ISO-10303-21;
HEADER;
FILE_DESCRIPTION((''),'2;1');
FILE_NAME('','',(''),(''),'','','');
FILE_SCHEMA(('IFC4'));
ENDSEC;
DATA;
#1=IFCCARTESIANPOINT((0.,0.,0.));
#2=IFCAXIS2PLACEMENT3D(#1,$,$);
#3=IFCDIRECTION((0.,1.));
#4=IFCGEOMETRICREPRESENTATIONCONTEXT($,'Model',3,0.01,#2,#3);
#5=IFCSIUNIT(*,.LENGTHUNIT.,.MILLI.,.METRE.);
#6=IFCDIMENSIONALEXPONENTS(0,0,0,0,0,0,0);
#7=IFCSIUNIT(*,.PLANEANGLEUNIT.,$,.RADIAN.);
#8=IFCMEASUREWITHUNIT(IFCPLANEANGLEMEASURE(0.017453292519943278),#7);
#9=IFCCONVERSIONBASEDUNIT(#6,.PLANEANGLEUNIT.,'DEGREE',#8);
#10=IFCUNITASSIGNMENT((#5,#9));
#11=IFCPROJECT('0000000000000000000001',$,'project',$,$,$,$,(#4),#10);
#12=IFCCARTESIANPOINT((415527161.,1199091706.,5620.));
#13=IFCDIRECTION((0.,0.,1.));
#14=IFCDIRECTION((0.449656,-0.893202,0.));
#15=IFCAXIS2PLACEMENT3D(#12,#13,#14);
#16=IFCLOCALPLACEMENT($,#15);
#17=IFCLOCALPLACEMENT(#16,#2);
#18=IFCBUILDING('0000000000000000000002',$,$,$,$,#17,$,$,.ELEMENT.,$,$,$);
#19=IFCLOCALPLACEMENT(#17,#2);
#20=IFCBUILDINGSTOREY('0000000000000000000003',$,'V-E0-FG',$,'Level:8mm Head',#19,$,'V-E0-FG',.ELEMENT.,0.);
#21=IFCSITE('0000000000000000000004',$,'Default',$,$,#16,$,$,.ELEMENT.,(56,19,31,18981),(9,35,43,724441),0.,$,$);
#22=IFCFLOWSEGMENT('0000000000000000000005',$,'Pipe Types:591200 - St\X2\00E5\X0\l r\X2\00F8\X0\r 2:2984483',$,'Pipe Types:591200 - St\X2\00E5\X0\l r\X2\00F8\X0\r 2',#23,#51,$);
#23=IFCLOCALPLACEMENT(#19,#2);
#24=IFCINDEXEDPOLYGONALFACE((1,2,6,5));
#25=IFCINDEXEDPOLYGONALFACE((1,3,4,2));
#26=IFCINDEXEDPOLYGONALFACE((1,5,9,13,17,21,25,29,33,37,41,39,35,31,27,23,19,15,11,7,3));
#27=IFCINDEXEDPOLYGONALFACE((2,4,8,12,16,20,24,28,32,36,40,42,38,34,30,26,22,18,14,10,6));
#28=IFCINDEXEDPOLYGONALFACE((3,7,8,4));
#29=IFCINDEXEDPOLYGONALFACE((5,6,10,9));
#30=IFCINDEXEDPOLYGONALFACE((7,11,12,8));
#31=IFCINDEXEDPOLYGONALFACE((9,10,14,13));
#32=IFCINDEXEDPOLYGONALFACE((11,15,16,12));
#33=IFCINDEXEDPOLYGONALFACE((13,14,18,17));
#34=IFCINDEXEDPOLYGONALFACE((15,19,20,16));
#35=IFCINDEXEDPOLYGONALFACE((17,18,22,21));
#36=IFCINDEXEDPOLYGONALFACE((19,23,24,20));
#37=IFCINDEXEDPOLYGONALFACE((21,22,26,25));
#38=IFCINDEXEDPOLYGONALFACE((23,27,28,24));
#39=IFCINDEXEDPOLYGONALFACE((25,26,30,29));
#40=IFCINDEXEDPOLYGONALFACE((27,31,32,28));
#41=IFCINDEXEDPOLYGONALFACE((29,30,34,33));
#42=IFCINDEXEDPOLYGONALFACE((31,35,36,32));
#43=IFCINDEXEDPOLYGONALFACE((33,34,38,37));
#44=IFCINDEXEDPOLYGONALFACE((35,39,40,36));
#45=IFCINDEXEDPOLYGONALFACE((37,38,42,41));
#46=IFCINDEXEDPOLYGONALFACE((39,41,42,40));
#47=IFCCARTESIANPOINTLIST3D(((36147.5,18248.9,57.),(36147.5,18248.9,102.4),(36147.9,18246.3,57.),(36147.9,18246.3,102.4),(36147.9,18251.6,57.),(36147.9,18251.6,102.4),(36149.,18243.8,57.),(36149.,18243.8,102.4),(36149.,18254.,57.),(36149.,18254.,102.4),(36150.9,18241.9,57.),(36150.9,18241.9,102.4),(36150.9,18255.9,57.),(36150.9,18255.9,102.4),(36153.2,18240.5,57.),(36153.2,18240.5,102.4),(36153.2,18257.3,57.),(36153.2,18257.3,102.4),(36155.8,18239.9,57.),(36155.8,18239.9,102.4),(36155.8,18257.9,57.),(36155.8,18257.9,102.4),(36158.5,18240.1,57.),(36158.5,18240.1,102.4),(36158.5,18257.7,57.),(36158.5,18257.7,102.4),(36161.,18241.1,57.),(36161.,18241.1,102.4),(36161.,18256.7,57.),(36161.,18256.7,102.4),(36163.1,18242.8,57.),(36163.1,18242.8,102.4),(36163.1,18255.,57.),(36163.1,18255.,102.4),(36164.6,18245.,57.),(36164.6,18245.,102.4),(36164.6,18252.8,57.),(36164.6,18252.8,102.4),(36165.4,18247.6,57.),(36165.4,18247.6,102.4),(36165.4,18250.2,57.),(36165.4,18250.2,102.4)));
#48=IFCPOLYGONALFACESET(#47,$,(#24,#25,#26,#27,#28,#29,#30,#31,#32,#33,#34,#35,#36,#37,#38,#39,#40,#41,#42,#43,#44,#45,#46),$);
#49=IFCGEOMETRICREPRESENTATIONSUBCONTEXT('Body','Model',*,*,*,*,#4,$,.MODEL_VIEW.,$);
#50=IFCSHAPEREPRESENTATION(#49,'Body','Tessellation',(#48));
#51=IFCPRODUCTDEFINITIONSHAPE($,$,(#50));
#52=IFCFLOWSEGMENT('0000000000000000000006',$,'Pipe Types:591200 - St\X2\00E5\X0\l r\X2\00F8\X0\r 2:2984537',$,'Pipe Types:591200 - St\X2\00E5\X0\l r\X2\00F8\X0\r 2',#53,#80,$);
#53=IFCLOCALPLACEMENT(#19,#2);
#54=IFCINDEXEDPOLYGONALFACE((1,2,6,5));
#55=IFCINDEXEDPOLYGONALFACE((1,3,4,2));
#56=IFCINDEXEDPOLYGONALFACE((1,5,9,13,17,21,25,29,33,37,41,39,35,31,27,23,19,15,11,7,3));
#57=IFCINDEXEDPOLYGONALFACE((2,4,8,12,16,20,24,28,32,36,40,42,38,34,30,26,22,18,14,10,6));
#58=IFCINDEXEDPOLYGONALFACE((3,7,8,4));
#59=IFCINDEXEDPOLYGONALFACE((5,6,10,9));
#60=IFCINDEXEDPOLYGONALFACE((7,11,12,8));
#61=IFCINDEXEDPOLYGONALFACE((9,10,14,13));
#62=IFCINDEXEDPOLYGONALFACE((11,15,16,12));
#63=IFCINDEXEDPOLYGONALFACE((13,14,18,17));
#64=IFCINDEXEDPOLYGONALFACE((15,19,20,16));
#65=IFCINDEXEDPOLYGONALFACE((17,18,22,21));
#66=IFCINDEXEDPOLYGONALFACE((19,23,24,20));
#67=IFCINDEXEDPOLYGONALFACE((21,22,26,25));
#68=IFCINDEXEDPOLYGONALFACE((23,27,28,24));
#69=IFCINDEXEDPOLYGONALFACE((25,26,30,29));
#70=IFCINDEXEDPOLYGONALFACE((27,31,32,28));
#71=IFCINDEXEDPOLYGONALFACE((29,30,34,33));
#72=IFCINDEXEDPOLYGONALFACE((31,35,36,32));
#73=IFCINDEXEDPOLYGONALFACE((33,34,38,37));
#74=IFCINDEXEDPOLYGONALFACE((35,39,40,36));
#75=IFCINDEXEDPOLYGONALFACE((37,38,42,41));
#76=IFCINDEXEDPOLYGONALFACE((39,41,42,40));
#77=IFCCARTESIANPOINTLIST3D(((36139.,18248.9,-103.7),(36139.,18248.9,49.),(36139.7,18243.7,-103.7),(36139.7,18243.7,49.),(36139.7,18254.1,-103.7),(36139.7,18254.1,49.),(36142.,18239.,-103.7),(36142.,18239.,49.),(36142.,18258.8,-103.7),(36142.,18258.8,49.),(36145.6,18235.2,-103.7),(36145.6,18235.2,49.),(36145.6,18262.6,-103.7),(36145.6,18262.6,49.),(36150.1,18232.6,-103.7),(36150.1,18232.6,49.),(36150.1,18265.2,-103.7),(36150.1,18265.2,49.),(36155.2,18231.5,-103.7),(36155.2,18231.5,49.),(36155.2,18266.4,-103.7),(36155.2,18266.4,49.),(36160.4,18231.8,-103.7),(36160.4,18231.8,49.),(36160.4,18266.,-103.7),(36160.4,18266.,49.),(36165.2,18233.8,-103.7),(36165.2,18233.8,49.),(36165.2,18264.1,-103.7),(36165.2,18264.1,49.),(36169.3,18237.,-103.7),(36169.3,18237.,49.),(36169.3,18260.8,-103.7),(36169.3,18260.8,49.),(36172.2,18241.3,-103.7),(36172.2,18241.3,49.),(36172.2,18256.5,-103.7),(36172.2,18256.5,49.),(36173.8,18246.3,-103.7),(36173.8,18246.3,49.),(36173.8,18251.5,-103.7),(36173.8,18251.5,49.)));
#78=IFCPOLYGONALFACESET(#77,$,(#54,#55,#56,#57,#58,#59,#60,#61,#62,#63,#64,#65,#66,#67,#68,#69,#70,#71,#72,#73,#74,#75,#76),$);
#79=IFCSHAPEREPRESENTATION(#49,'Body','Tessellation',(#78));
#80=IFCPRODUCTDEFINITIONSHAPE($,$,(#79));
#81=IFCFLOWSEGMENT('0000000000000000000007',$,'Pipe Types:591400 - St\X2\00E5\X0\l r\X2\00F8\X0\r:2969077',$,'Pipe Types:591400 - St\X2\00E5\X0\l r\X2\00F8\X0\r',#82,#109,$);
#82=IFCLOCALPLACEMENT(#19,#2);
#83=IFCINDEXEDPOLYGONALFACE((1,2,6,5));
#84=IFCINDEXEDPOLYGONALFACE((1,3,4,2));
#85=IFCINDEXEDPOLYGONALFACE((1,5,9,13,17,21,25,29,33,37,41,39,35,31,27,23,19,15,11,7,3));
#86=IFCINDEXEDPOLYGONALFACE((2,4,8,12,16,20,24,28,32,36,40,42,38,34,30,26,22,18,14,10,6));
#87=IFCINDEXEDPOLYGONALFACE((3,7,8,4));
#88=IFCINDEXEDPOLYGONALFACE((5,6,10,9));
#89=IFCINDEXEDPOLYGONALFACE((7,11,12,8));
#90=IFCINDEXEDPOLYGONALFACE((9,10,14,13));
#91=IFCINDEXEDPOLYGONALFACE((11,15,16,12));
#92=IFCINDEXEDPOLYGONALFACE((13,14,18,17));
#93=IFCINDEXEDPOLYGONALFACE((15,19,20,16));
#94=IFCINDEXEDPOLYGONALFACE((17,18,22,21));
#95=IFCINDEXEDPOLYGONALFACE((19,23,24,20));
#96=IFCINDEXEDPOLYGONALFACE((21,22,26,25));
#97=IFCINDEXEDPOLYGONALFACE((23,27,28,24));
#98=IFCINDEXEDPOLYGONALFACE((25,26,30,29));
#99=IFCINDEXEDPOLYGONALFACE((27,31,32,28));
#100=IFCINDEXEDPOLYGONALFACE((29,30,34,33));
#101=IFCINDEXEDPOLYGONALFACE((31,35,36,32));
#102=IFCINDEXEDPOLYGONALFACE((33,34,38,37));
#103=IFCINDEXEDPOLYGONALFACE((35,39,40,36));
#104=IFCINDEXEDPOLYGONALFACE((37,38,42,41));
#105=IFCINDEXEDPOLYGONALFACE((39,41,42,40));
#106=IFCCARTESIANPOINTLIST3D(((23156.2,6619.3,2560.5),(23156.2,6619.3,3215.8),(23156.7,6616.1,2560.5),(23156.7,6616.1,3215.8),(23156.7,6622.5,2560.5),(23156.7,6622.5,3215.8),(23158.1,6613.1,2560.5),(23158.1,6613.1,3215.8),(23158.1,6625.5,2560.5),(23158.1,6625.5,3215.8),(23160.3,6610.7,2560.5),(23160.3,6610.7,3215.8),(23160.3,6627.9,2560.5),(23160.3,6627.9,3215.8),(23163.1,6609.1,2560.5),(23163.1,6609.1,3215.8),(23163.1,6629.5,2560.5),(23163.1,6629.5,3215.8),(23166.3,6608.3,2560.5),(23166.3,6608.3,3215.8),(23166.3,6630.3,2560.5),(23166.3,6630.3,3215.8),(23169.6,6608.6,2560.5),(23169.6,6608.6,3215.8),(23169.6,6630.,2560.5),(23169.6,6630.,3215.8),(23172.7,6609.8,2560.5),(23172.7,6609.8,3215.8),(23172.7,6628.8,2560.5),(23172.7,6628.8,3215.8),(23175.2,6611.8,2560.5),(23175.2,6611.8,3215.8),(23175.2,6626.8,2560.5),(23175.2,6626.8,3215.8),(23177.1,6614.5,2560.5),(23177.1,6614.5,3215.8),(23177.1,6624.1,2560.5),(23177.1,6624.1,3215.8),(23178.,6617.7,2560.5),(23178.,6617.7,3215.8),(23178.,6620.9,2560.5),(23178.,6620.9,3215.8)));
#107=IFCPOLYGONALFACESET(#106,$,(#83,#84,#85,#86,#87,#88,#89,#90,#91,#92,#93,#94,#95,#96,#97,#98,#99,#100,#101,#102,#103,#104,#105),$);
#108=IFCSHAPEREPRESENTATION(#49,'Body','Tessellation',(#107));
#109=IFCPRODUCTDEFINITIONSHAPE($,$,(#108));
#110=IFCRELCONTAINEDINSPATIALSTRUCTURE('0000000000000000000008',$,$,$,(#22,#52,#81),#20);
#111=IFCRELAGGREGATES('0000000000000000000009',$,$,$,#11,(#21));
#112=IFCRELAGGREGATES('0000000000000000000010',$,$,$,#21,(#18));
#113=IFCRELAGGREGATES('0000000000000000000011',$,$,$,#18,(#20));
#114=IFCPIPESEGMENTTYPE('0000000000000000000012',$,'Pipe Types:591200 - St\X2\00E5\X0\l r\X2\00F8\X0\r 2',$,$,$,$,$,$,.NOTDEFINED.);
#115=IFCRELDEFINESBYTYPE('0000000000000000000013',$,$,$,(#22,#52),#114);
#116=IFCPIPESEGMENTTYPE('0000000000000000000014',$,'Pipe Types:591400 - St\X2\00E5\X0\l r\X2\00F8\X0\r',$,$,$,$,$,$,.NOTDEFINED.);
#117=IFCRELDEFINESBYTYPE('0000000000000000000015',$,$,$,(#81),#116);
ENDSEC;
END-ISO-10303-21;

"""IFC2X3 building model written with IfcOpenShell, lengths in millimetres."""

from ifc_helpers import new_model, entity, si_unit, converted_unit, direction, frame, frame_2d, origin, origin_2d_with_axis, place, context, subcontext, project, spatial, circle, extrude, type_object, element, save


model = new_model("IFC2X3")

# Units and contexts
model_context = context("Model", 3, precision=0.01, world=origin(), true_north=direction((0.0, 1.0)))
body_context = subcontext(model_context, "Body", "Model", "MODEL_VIEW")
ifc_project = project(units=[si_unit("LENGTHUNIT", "METRE", prefix="MILLI"), converted_unit("PLANEANGLEUNIT", "DEGREE", entity("IfcPlaneAngleMeasure", 0.017453292519943278), si_unit("PLANEANGLEUNIT", "RADIAN"), dimensions=[0, 0, 0, 0, 0, 0, 0])], contexts=[model_context])

# Site, building, storey
site_placement = place(None, frame((415527161.0, 1199091706.0, 5620.0), z_axis=(0.0, 0.0, 1.0), x_axis=(0.449656, -0.893202, 0.0)))
site = spatial("IfcSite", under=ifc_project, at=site_placement, Name="Default", CompositionType="ELEMENT", RefLatitude=(56, 19, 31, 18981), RefLongitude=(9, 35, 43, 724441), RefElevation=0.0)
building_placement = place(site_placement, origin())
building = spatial("IfcBuilding", under=site, at=building_placement, CompositionType="ELEMENT")
storey_placement = place(building_placement, origin())
storey = spatial("IfcBuildingStorey", under=building, at=storey_placement, Name="V-E0-FG", ObjectType="Level:8mm Head", LongName="V-E0-FG", CompositionType="ELEMENT", Elevation=0.0)

# Flow segments
pipe_segment_type_1 = type_object("IfcPipeSegmentType", Name="Pipe Types:591200 - Stål rør 2", PredefinedType="NOTDEFINED")
flow_segment_1_placement = place(storey_placement, origin())
element("IfcFlowSegment", 1, at=flow_segment_1_placement, inside=storey, type_object=pipe_segment_type_1, Name="Pipe Types:591200 - Stål rør 2:2984483", ObjectType="Pipe Types:591200 - Stål rør 2", context=body_context, shape_type="SweptSolid", body=[
    extrude(circle(Radius=9.0, at=frame_2d((0.0, 0.0), x_axis=(1.0, 0.0))), frame((36156.5, 18248.9, 57.0), z_axis=(0.0, 0.0, 1.0), x_axis=(-1.0, 0.0, 0.0)), (0.0, 0.0, 1.0), 45.4),
])
flow_segment_2_placement = place(storey_placement, origin())
element("IfcFlowSegment", 2, at=flow_segment_2_placement, inside=storey, type_object=pipe_segment_type_1, Name="Pipe Types:591200 - Stål rør 2:2984537", ObjectType="Pipe Types:591200 - Stål rør 2", context=body_context, shape_type="SweptSolid", body=[
    extrude(circle(Radius=17.5, at=origin_2d_with_axis()), frame((36156.5, 18248.9, -103.7), z_axis=(0.0, 0.0, 1.0), x_axis=(-1.0, 0.0, 0.0)), (0.0, 0.0, 1.0), 152.7),
])
pipe_segment_type_2 = type_object("IfcPipeSegmentType", Name="Pipe Types:591400 - Stål rør", PredefinedType="NOTDEFINED")
flow_segment_3_placement = place(storey_placement, origin())
element("IfcFlowSegment", 3, at=flow_segment_3_placement, inside=storey, type_object=pipe_segment_type_2, Name="Pipe Types:591400 - Stål rør:2969077", ObjectType="Pipe Types:591400 - Stål rør", context=body_context, shape_type="SweptSolid", body=[
    extrude(circle(Radius=11.0, at=origin_2d_with_axis()), frame((23167.2, 6619.3, 2560.5), z_axis=(0.0, 0.0, 1.0), x_axis=(-1.0, 0.0, 0.0)), (0.0, 0.0, 1.0), 655.3),
])

save(model, "model.ifc")
